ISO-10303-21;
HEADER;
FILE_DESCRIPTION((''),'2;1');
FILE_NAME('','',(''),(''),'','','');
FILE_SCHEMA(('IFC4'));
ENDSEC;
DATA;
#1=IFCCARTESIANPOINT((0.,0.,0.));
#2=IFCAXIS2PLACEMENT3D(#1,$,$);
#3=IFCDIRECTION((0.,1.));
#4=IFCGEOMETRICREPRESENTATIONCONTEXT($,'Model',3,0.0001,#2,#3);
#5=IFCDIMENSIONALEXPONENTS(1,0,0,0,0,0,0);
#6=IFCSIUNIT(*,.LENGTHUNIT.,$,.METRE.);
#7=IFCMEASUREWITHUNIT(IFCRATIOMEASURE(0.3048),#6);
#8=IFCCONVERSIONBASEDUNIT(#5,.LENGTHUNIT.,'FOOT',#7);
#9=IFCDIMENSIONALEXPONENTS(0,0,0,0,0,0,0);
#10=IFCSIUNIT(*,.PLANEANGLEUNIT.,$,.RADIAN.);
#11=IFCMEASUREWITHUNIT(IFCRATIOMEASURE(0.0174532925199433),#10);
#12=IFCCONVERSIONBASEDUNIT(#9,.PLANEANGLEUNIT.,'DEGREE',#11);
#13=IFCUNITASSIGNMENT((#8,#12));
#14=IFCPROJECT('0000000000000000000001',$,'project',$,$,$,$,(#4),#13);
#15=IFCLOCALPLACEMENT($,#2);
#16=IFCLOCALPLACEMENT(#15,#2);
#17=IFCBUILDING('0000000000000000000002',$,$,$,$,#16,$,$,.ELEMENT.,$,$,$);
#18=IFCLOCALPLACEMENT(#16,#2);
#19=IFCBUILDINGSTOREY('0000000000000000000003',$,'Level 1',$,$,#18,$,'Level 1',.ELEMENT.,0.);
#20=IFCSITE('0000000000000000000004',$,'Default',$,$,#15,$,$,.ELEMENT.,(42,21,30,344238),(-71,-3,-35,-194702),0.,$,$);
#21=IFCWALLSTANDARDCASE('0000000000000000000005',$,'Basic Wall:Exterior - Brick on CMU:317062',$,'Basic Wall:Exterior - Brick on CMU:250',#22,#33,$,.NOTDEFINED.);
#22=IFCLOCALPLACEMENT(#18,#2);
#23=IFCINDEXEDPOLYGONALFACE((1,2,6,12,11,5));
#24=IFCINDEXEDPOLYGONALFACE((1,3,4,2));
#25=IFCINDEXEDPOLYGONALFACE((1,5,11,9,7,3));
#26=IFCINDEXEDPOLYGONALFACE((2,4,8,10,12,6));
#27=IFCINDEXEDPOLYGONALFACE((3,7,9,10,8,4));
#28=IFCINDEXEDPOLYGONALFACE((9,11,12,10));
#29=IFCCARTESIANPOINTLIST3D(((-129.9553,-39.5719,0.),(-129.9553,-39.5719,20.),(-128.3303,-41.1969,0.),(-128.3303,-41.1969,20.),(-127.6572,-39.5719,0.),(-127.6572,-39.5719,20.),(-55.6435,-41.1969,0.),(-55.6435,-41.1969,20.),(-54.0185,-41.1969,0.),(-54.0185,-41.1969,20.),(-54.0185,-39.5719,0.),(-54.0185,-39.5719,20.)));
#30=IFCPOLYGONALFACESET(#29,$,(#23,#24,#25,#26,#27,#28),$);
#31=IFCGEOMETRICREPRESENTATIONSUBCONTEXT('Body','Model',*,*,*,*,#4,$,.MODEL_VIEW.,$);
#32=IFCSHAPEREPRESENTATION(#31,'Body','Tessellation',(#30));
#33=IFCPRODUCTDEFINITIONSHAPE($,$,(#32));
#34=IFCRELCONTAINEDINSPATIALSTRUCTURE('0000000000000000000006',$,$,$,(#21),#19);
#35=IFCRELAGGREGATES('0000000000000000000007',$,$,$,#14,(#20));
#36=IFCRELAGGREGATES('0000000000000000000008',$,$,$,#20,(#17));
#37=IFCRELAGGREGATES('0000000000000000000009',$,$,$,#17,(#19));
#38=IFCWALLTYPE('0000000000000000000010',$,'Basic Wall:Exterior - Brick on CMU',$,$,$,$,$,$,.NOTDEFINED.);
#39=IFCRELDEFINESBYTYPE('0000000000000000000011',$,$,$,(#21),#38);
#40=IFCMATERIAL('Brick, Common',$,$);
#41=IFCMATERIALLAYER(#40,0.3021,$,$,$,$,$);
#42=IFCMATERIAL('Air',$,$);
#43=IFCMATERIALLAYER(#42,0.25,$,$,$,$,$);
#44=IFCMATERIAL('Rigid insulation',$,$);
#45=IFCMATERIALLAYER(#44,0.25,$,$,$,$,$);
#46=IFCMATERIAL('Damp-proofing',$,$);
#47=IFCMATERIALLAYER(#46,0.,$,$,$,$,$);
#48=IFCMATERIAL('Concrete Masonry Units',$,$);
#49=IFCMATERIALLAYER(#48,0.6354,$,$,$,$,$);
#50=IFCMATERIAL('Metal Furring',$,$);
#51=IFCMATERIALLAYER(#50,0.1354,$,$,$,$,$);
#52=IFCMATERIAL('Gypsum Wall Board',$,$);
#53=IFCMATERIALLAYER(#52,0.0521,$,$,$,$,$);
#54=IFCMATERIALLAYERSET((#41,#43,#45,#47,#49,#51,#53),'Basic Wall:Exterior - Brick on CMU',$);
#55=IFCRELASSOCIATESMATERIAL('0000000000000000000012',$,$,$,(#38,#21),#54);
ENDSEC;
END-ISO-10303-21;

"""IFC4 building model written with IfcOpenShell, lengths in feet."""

from ifc_helpers import new_model, entity, si_unit, converted_unit, direction, frame, origin, place, context, subcontext, project, spatial, polyline, outline, extrude, material, layer, layer_set, layer_usage, type_object, element, save


model = new_model("IFC4")

# Units and contexts
model_context = context("Model", 3, precision=0.0001, world=origin(), true_north=direction((0.0, 1.0)))
body_context = subcontext(model_context, "Body", "Model", "MODEL_VIEW")
ifc_project = project(units=[converted_unit("LENGTHUNIT", "FOOT", entity("IfcRatioMeasure", 0.3048), si_unit("LENGTHUNIT", "METRE"), dimensions=[1, 0, 0, 0, 0, 0, 0]), converted_unit("PLANEANGLEUNIT", "DEGREE", entity("IfcRatioMeasure", 0.0174532925199433), si_unit("PLANEANGLEUNIT", "RADIAN"), dimensions=[0, 0, 0, 0, 0, 0, 0])], contexts=[model_context])

# Site, building, storey
site_placement = place(None, origin())
site = spatial("IfcSite", under=ifc_project, at=site_placement, Name="Default", CompositionType="ELEMENT", RefLatitude=(42, 21, 30, 344238), RefLongitude=(-71, -3, -35, -194702), RefElevation=0.0)
building_placement = place(site_placement, origin())
building = spatial("IfcBuilding", under=site, at=building_placement, CompositionType="ELEMENT")
storey_placement = place(building_placement, origin())
storey = spatial("IfcBuildingStorey", under=building, at=storey_placement, Name="Level 1", LongName="Level 1", CompositionType="ELEMENT", Elevation=0.0)

# Wall
ifc_material_1 = material(Name="Brick, Common")
ifc_layer_1 = layer(ifc_material_1, 0.3021)
ifc_material_2 = material(Name="Air")
ifc_layer_2 = layer(ifc_material_2, 0.25)
ifc_material_3 = material(Name="Rigid insulation")
ifc_layer_3 = layer(ifc_material_3, 0.25)
ifc_material_4 = material(Name="Damp-proofing")
ifc_layer_4 = layer(ifc_material_4, 0.0)
ifc_material_5 = material(Name="Concrete Masonry Units")
ifc_layer_5 = layer(ifc_material_5, 0.6354)
ifc_material_6 = material(Name="Metal Furring")
ifc_layer_6 = layer(ifc_material_6, 0.1354)
ifc_material_7 = material(Name="Gypsum Wall Board")
ifc_layer_7 = layer(ifc_material_7, 0.0521)
ifc_layer_set = layer_set([ifc_layer_1, ifc_layer_2, ifc_layer_3, ifc_layer_4, ifc_layer_5, ifc_layer_6, ifc_layer_7], Name="Basic Wall:Exterior - Brick on CMU")
ifc_layer_usage = layer_usage(ifc_layer_set, "AXIS2", "NEGATIVE", 0.8125)
wall_type = type_object("IfcWallType", Name="Basic Wall:Exterior - Brick on CMU", PredefinedType="NOTDEFINED", material=ifc_layer_set)
wall_placement = place(storey_placement, frame((-54.0185, -40.3844, 0.0), z_axis=(0.0, 0.0, 1.0), x_axis=(-1.0, 0.0, 0.0)))
element("IfcWallStandardCase", 1, at=wall_placement, inside=storey, type_object=wall_type, material=ifc_layer_usage, Name="Basic Wall:Exterior - Brick on CMU:317062", ObjectType="Basic Wall:Exterior - Brick on CMU:250", PredefinedType="NOTDEFINED", context=body_context, shape_type="SweptSolid", body=[
    extrude(outline(polyline([(75.9368, -0.8125), (74.3118, 0.8125), (1.625, 0.8125), (0.0, 0.8125), (0.0, -0.8125), (73.6387, -0.8125), (75.9368, -0.8125)])), origin(), (0.0, 0.0, 1.0), 20.0),
])

save(model, "model.ifc")
